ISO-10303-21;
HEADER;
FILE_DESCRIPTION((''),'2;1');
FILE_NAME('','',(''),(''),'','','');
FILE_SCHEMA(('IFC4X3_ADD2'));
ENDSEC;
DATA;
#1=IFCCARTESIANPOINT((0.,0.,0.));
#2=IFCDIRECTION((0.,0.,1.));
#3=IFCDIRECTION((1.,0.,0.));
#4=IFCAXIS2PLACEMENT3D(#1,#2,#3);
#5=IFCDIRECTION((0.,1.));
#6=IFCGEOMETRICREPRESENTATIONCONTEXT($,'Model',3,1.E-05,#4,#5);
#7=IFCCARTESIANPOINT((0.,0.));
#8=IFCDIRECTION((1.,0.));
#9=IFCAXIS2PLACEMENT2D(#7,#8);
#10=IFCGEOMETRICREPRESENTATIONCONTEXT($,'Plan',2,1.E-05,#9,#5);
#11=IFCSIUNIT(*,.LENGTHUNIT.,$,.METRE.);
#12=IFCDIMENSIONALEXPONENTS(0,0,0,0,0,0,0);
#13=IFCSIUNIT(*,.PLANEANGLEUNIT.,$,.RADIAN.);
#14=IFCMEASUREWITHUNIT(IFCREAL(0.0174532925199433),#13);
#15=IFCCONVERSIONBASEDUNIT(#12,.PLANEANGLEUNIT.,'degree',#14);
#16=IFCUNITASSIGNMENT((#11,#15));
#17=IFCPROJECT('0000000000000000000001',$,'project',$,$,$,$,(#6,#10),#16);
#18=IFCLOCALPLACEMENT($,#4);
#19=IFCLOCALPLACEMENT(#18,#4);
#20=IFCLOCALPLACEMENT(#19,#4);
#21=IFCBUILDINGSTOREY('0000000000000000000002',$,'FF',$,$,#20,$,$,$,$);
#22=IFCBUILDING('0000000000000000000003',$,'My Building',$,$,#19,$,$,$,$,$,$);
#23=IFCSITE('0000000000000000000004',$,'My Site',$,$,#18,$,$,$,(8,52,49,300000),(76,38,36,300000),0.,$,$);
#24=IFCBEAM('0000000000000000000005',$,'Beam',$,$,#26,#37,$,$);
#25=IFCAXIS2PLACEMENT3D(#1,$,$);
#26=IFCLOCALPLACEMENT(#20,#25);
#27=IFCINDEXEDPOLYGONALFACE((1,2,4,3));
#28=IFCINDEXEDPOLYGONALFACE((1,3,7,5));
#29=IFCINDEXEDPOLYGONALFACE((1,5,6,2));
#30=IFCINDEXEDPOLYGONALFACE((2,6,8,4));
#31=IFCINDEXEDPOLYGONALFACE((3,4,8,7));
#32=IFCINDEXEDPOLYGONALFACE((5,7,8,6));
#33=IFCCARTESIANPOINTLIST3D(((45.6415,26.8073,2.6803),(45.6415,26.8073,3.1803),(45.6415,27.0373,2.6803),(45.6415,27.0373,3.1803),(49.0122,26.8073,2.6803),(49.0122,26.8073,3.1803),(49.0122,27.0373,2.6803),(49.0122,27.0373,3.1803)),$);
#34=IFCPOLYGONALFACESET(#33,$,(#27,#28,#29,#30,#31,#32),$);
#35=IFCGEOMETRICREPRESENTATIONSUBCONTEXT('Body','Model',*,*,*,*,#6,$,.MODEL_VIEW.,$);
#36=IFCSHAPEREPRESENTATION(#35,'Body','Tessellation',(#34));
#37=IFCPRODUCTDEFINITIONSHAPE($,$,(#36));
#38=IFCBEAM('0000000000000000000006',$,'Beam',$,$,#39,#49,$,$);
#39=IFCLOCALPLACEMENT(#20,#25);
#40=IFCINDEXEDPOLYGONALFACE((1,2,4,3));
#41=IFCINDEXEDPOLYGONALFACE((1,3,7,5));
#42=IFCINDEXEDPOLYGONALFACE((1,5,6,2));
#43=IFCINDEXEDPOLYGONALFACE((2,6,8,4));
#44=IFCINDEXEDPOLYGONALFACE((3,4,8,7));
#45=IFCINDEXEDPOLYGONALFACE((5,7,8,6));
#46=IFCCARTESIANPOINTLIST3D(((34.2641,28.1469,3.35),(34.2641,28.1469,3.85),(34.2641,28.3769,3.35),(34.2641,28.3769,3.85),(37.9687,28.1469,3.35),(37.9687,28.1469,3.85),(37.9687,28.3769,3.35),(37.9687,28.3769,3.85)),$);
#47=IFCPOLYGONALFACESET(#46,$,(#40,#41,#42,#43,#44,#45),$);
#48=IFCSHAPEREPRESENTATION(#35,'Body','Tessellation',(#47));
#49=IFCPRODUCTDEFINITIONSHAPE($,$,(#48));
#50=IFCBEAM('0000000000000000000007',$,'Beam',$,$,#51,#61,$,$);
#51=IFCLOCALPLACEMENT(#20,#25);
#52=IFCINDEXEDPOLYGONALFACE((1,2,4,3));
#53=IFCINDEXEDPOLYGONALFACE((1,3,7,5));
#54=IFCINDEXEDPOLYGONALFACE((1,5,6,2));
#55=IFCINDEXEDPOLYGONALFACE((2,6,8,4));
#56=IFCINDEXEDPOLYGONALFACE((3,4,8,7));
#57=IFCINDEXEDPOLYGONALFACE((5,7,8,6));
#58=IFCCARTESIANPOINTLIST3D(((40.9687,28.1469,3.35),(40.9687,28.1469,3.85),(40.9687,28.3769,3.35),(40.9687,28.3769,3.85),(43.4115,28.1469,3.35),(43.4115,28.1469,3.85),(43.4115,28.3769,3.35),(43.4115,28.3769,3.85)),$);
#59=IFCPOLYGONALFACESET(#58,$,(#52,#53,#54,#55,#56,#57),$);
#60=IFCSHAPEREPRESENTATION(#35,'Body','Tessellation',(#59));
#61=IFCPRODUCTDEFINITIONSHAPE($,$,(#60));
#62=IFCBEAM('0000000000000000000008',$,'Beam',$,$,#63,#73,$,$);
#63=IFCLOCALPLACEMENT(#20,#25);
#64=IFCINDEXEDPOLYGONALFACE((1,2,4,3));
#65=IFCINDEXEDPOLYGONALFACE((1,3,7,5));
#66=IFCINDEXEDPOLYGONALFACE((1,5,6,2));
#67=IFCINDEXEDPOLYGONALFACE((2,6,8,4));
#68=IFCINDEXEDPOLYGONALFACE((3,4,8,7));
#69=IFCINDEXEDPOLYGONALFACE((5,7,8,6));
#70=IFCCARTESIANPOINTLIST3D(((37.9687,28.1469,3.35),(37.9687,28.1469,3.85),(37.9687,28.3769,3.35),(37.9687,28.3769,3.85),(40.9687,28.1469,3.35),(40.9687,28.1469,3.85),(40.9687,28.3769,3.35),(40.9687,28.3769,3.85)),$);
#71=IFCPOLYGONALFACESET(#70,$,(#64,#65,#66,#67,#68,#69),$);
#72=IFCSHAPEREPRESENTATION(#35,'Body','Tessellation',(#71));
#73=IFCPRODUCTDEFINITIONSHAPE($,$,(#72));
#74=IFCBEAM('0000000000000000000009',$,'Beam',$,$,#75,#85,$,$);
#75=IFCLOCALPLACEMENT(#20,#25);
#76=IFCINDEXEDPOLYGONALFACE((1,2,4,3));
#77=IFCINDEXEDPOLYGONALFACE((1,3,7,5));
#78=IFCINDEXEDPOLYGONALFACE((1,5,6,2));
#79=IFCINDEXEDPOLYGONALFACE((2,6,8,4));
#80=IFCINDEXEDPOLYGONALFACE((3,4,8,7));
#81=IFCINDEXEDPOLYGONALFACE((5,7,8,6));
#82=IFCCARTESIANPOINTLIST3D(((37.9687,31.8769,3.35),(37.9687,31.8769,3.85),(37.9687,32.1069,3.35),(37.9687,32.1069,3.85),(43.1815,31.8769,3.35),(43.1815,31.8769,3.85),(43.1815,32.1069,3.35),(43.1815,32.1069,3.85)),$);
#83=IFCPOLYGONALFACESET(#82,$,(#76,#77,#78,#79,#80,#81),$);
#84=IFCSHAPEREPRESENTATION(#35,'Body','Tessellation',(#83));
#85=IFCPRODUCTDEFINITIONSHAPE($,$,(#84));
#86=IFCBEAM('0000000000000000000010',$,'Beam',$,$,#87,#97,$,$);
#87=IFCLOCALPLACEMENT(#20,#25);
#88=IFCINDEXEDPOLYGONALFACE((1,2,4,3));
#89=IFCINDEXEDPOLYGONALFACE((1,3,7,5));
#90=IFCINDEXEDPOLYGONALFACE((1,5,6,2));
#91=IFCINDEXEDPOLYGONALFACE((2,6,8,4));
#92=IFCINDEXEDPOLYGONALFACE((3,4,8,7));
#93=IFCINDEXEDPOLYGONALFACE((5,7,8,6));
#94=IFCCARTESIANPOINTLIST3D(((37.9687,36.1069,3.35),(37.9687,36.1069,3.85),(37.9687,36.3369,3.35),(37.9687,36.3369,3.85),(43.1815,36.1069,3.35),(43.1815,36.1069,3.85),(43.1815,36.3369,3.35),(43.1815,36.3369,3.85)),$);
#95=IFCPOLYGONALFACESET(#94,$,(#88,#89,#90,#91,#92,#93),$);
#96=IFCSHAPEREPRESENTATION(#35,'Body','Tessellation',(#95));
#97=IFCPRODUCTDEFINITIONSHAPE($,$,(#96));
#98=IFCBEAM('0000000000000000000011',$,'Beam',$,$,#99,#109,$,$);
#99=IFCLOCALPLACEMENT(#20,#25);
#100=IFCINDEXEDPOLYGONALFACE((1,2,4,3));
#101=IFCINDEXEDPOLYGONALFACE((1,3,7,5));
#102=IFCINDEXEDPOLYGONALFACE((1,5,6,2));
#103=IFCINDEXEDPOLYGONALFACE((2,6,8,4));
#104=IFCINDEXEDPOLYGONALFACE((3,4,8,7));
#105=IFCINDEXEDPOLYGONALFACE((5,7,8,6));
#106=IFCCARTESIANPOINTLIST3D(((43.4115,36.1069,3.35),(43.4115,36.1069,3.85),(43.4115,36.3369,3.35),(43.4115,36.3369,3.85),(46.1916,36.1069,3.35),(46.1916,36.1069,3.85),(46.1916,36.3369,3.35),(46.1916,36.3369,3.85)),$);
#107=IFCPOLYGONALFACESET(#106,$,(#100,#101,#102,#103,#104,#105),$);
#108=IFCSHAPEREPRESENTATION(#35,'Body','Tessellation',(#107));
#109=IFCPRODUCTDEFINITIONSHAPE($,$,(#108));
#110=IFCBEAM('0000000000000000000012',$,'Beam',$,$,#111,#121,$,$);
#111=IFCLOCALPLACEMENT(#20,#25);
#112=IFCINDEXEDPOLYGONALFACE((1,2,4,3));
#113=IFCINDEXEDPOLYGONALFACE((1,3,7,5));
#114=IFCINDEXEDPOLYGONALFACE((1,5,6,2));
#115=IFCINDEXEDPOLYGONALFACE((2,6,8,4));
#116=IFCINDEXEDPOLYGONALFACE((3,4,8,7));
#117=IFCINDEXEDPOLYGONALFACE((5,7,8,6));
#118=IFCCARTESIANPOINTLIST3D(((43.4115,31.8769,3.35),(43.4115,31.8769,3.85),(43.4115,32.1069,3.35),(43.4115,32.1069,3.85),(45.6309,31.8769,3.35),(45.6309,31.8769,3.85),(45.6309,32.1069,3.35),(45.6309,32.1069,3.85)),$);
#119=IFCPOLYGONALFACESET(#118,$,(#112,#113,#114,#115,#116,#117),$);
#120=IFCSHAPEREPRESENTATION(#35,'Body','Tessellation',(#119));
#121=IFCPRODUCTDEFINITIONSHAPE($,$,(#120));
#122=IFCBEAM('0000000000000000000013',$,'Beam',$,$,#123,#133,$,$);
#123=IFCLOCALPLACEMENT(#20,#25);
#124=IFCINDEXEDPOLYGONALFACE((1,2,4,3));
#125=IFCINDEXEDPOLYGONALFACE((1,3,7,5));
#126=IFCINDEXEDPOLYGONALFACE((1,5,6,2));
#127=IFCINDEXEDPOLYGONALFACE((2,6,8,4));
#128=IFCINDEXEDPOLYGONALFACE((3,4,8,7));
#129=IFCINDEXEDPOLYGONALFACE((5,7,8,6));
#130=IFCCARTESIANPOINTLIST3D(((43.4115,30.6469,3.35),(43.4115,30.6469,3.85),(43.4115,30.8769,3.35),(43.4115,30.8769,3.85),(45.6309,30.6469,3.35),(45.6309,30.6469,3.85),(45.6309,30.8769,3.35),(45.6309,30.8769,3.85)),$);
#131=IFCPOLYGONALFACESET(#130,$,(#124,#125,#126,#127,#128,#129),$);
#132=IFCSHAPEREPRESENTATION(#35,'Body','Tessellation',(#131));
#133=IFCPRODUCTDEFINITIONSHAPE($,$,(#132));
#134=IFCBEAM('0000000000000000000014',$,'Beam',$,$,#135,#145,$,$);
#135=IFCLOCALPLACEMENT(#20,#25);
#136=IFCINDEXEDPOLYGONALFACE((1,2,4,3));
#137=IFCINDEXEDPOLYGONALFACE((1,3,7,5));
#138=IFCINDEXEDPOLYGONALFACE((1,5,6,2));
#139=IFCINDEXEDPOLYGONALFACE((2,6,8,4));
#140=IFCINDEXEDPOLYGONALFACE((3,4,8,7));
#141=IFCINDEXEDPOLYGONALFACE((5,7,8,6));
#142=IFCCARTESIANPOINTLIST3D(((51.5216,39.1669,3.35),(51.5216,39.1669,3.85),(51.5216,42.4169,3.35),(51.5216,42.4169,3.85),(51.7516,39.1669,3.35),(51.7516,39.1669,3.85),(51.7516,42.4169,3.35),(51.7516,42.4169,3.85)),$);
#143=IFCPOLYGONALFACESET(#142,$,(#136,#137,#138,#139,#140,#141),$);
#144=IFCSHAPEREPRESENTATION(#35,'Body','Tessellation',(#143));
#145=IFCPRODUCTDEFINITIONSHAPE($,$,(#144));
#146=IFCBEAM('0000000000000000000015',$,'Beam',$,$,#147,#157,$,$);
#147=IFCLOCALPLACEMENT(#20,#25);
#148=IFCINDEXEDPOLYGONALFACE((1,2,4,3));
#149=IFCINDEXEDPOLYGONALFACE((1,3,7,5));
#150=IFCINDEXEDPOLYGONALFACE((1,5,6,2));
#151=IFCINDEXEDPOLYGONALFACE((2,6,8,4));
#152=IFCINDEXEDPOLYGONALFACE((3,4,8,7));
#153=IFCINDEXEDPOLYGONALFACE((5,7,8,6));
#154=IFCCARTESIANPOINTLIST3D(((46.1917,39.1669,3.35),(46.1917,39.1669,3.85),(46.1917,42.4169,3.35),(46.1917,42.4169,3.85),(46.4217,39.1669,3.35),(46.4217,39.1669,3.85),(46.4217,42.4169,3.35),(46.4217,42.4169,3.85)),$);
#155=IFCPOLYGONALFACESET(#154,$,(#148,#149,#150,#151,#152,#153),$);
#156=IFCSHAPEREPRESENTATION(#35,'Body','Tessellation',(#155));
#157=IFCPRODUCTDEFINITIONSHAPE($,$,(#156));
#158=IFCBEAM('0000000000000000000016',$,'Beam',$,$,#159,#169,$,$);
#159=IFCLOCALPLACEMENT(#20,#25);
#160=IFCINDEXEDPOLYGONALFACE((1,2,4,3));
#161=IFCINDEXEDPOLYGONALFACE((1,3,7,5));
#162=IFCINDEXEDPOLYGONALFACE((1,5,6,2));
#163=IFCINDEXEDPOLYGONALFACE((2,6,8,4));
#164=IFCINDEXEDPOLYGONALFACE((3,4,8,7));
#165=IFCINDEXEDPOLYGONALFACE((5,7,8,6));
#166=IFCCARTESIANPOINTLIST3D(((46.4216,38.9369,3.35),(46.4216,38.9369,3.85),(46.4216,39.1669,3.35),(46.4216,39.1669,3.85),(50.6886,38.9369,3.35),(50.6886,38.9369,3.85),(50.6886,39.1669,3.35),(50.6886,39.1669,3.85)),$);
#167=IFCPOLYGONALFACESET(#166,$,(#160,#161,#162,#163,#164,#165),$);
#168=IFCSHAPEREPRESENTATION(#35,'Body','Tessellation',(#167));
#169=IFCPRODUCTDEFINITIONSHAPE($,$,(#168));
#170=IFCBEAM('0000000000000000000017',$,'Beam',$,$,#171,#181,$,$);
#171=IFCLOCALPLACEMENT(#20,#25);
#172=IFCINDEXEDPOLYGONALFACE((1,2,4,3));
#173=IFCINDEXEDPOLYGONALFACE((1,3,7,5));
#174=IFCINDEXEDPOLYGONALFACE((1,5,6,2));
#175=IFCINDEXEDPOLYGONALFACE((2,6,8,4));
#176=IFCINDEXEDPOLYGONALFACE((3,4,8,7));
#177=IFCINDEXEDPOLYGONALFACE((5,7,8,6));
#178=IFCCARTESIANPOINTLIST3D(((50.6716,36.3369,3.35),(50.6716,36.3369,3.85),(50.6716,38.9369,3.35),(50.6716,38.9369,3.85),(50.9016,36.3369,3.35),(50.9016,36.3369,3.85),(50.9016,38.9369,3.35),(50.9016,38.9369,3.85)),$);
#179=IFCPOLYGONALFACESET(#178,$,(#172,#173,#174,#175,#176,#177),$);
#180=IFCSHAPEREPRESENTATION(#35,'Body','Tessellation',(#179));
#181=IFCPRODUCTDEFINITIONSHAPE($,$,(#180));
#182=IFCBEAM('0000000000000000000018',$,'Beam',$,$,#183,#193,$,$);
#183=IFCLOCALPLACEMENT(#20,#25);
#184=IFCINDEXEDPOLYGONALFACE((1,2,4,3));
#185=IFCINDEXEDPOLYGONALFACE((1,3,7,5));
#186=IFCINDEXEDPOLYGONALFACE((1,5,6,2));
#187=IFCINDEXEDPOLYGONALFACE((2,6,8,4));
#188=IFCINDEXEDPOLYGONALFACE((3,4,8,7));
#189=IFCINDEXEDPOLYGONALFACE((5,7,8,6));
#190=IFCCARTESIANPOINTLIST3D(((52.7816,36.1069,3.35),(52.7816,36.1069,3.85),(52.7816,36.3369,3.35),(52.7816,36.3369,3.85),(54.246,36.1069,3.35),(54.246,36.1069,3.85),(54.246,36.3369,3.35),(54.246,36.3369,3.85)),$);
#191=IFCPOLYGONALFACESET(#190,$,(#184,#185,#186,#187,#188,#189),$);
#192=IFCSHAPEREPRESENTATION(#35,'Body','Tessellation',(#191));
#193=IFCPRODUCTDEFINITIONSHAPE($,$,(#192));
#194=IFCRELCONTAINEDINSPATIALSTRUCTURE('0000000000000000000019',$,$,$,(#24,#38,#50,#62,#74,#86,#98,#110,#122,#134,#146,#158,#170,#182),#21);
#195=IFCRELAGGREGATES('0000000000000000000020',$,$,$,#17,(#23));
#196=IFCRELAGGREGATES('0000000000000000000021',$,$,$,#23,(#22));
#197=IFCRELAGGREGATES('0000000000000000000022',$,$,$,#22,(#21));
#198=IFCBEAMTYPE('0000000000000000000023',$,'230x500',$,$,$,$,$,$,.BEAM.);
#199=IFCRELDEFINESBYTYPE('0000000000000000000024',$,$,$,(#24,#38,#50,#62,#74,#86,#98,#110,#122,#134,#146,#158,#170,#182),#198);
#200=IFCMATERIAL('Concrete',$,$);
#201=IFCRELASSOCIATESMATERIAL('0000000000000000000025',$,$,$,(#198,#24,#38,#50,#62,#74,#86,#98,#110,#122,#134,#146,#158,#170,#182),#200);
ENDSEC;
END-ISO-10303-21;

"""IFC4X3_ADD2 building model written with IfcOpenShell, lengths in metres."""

from ifc_helpers import new_model, entity, si_unit, converted_unit, direction, frame, origin_with_axes, origin_2d_with_axis, place, context, subcontext, project, spatial, rectangle, extrude, material, material_profile, profile_set, profile_usage, type_object, element, save


model = new_model("IFC4X3_ADD2")

# Units and contexts
model_context = context("Model", 3, precision=1e-05, world=origin_with_axes(), true_north=direction((0.0, 1.0)))
plan_context = context("Plan", 2, precision=1e-05, world=origin_2d_with_axis(), true_north=direction((0.0, 1.0)))
body_context = subcontext(model_context, "Body", "Model", "MODEL_VIEW")
ifc_project = project(units=[si_unit("LENGTHUNIT", "METRE"), converted_unit("PLANEANGLEUNIT", "degree", entity("IfcReal", 0.0174532925199433), si_unit("PLANEANGLEUNIT", "RADIAN"), dimensions=[0, 0, 0, 0, 0, 0, 0])], contexts=[model_context, plan_context])

# Site, building, storey
site_placement = place(None, origin_with_axes())
site = spatial("IfcSite", under=ifc_project, at=site_placement, Name="My Site", RefLatitude=(8, 52, 49, 300000), RefLongitude=(76, 38, 36, 300000), RefElevation=0.0)
building_placement = place(site_placement, origin_with_axes())
building = spatial("IfcBuilding", under=site, at=building_placement, Name="My Building")
storey_placement = place(building_placement, origin_with_axes())
storey = spatial("IfcBuildingStorey", under=building, at=storey_placement, Name="FF")

# Beams
ifc_material_1 = material(Name="Concrete")
ifc_material_profile = material_profile(ifc_material_1, rectangle(XDim=0.23, YDim=0.5))
ifc_profile_set = profile_set([ifc_material_profile])
ifc_profile_usage_1 = profile_usage(ifc_profile_set, cardinal=5)
beam_type = type_object("IfcBeamType", Name="230x500", PredefinedType="BEAM", material=ifc_profile_set)
beam_1_placement = place(storey_placement, frame((45.6415, 26.9223, 2.9303), z_axis=(1.0, 0.0, 0.0), x_axis=(0.0, 1.0, 0.0)))
element("IfcBeam", 1, at=beam_1_placement, inside=storey, type_object=beam_type, material=ifc_profile_usage_1, Name="Beam", context=body_context, shape_type="SweptSolid", body=[
    extrude(rectangle(XDim=0.23, YDim=0.5), origin_with_axes(), (0.0, 0.0, 1.0), 3.3707),
])
ifc_profile_usage_2 = profile_usage(ifc_profile_set, cardinal=5)
beam_2_placement = place(storey_placement, frame((34.2641, 28.2619, 3.6), z_axis=(1.0, 0.0, 0.0), x_axis=(0.0, 1.0, 0.0)))
element("IfcBeam", 2, at=beam_2_placement, inside=storey, type_object=beam_type, material=ifc_profile_usage_2, Name="Beam", context=body_context, shape_type="SweptSolid", body=[
    extrude(rectangle(XDim=0.23, YDim=0.5), origin_with_axes(), (0.0, 0.0, 1.0), 3.7046),
])
ifc_profile_usage_3 = profile_usage(ifc_profile_set, cardinal=5)
beam_3_placement = place(storey_placement, frame((40.9687, 28.2619, 3.6), z_axis=(1.0, 0.0, 0.0), x_axis=(0.0, 1.0, 0.0)))
element("IfcBeam", 3, at=beam_3_placement, inside=storey, type_object=beam_type, material=ifc_profile_usage_3, Name="Beam", context=body_context, shape_type="SweptSolid", body=[
    extrude(rectangle(XDim=0.23, YDim=0.5), origin_with_axes(), (0.0, 0.0, 1.0), 2.4428),
])
ifc_profile_usage_4 = profile_usage(ifc_profile_set, cardinal=5)
beam_4_placement = place(storey_placement, frame((37.9687, 28.2619, 3.6), z_axis=(1.0, 0.0, 0.0), x_axis=(0.0, 1.0, 0.0)))
element("IfcBeam", 4, at=beam_4_placement, inside=storey, type_object=beam_type, material=ifc_profile_usage_4, Name="Beam", context=body_context, shape_type="SweptSolid", body=[
    extrude(rectangle(XDim=0.23, YDim=0.5), origin_with_axes(), (0.0, 0.0, 1.0), 3.0),
])
ifc_profile_usage_5 = profile_usage(ifc_profile_set, cardinal=5)
beam_5_placement = place(storey_placement, frame((37.9687, 31.9919, 3.6), z_axis=(1.0, 0.0, 0.0), x_axis=(0.0, 1.0, 0.0)))
element("IfcBeam", 5, at=beam_5_placement, inside=storey, type_object=beam_type, material=ifc_profile_usage_5, Name="Beam", context=body_context, shape_type="SweptSolid", body=[
    extrude(rectangle(XDim=0.23, YDim=0.5), origin_with_axes(), (0.0, 0.0, 1.0), 5.2128),
])
ifc_profile_usage_6 = profile_usage(ifc_profile_set, cardinal=5)
beam_6_placement = place(storey_placement, frame((37.9687, 36.2219, 3.6), z_axis=(1.0, 0.0, 0.0), x_axis=(0.0, 1.0, 0.0)))
element("IfcBeam", 6, at=beam_6_placement, inside=storey, type_object=beam_type, material=ifc_profile_usage_6, Name="Beam", context=body_context, shape_type="SweptSolid", body=[
    extrude(rectangle(XDim=0.23, YDim=0.5), origin_with_axes(), (0.0, 0.0, 1.0), 5.2128),
])
ifc_profile_usage_7 = profile_usage(ifc_profile_set, cardinal=5)
beam_7_placement = place(storey_placement, frame((43.4115, 36.2219, 3.6), z_axis=(1.0, 0.0, 0.0), x_axis=(0.0, 1.0, 0.0)))
element("IfcBeam", 7, at=beam_7_placement, inside=storey, type_object=beam_type, material=ifc_profile_usage_7, Name="Beam", context=body_context, shape_type="SweptSolid", body=[
    extrude(rectangle(XDim=0.23, YDim=0.5), origin_with_axes(), (0.0, 0.0, 1.0), 2.7801),
])
ifc_profile_usage_8 = profile_usage(ifc_profile_set, cardinal=5)
beam_8_placement = place(storey_placement, frame((43.4115, 31.9919, 3.6), z_axis=(1.0, 0.0, 0.0), x_axis=(0.0, 1.0, 0.0)))
element("IfcBeam", 8, at=beam_8_placement, inside=storey, type_object=beam_type, material=ifc_profile_usage_8, Name="Beam", context=body_context, shape_type="SweptSolid", body=[
    extrude(rectangle(XDim=0.23, YDim=0.5), origin_with_axes(), (0.0, 0.0, 1.0), 2.2194),
])
ifc_profile_usage_9 = profile_usage(ifc_profile_set, cardinal=5)
beam_9_placement = place(storey_placement, frame((43.4115, 30.7619, 3.6), z_axis=(1.0, 0.0, 0.0), x_axis=(0.0, 1.0, 0.0)))
element("IfcBeam", 9, at=beam_9_placement, inside=storey, type_object=beam_type, material=ifc_profile_usage_9, Name="Beam", context=body_context, shape_type="SweptSolid", body=[
    extrude(rectangle(XDim=0.23, YDim=0.5), origin_with_axes(), (0.0, 0.0, 1.0), 2.2194),
])
ifc_profile_usage_10 = profile_usage(ifc_profile_set, cardinal=5)
beam_10_placement = place(storey_placement, frame((51.6366, 39.1669, 3.6), z_axis=(0.0, 1.0, 0.0), x_axis=(-1.0, 0.0, 0.0)))
element("IfcBeam", 10, at=beam_10_placement, inside=storey, type_object=beam_type, material=ifc_profile_usage_10, Name="Beam", context=body_context, shape_type="SweptSolid", body=[
    extrude(rectangle(XDim=0.23, YDim=0.5), origin_with_axes(), (0.0, 0.0, 1.0), 3.25),
])
ifc_profile_usage_11 = profile_usage(ifc_profile_set, cardinal=5)
beam_11_placement = place(storey_placement, frame((46.3067, 39.1669, 3.6), z_axis=(0.0, 1.0, 0.0), x_axis=(-1.0, 0.0, 0.0)))
element("IfcBeam", 11, at=beam_11_placement, inside=storey, type_object=beam_type, material=ifc_profile_usage_11, Name="Beam", context=body_context, shape_type="SweptSolid", body=[
    extrude(rectangle(XDim=0.23, YDim=0.5), origin_with_axes(), (0.0, 0.0, 1.0), 3.25),
])
ifc_profile_usage_12 = profile_usage(ifc_profile_set, cardinal=5)
beam_12_placement = place(storey_placement, frame((46.4216, 39.0519, 3.6), z_axis=(1.0, 0.0, 0.0), x_axis=(0.0, 1.0, 0.0)))
element("IfcBeam", 12, at=beam_12_placement, inside=storey, type_object=beam_type, material=ifc_profile_usage_12, Name="Beam", context=body_context, shape_type="SweptSolid", body=[
    extrude(rectangle(XDim=0.23, YDim=0.5), origin_with_axes(), (0.0, 0.0, 1.0), 4.267),
])
ifc_profile_usage_13 = profile_usage(ifc_profile_set, cardinal=5)
beam_13_placement = place(storey_placement, frame((50.7866, 36.3369, 3.6), z_axis=(0.0, 1.0, 0.0), x_axis=(-1.0, 0.0, 0.0)))
element("IfcBeam", 13, at=beam_13_placement, inside=storey, type_object=beam_type, material=ifc_profile_usage_13, Name="Beam", context=body_context, shape_type="SweptSolid", body=[
    extrude(rectangle(XDim=0.23, YDim=0.5), origin_with_axes(), (0.0, 0.0, 1.0), 2.6),
])
ifc_profile_usage_14 = profile_usage(ifc_profile_set, cardinal=5)
beam_14_placement = place(storey_placement, frame((52.7816, 36.2219, 3.6), z_axis=(1.0, 0.0, 0.0), x_axis=(0.0, 1.0, 0.0)))
element("IfcBeam", 14, at=beam_14_placement, inside=storey, type_object=beam_type, material=ifc_profile_usage_14, Name="Beam", context=body_context, shape_type="SweptSolid", body=[
    extrude(rectangle(XDim=0.23, YDim=0.5), origin_with_axes(), (0.0, 0.0, 1.0), 1.4644),
])

save(model, "model.ifc")
